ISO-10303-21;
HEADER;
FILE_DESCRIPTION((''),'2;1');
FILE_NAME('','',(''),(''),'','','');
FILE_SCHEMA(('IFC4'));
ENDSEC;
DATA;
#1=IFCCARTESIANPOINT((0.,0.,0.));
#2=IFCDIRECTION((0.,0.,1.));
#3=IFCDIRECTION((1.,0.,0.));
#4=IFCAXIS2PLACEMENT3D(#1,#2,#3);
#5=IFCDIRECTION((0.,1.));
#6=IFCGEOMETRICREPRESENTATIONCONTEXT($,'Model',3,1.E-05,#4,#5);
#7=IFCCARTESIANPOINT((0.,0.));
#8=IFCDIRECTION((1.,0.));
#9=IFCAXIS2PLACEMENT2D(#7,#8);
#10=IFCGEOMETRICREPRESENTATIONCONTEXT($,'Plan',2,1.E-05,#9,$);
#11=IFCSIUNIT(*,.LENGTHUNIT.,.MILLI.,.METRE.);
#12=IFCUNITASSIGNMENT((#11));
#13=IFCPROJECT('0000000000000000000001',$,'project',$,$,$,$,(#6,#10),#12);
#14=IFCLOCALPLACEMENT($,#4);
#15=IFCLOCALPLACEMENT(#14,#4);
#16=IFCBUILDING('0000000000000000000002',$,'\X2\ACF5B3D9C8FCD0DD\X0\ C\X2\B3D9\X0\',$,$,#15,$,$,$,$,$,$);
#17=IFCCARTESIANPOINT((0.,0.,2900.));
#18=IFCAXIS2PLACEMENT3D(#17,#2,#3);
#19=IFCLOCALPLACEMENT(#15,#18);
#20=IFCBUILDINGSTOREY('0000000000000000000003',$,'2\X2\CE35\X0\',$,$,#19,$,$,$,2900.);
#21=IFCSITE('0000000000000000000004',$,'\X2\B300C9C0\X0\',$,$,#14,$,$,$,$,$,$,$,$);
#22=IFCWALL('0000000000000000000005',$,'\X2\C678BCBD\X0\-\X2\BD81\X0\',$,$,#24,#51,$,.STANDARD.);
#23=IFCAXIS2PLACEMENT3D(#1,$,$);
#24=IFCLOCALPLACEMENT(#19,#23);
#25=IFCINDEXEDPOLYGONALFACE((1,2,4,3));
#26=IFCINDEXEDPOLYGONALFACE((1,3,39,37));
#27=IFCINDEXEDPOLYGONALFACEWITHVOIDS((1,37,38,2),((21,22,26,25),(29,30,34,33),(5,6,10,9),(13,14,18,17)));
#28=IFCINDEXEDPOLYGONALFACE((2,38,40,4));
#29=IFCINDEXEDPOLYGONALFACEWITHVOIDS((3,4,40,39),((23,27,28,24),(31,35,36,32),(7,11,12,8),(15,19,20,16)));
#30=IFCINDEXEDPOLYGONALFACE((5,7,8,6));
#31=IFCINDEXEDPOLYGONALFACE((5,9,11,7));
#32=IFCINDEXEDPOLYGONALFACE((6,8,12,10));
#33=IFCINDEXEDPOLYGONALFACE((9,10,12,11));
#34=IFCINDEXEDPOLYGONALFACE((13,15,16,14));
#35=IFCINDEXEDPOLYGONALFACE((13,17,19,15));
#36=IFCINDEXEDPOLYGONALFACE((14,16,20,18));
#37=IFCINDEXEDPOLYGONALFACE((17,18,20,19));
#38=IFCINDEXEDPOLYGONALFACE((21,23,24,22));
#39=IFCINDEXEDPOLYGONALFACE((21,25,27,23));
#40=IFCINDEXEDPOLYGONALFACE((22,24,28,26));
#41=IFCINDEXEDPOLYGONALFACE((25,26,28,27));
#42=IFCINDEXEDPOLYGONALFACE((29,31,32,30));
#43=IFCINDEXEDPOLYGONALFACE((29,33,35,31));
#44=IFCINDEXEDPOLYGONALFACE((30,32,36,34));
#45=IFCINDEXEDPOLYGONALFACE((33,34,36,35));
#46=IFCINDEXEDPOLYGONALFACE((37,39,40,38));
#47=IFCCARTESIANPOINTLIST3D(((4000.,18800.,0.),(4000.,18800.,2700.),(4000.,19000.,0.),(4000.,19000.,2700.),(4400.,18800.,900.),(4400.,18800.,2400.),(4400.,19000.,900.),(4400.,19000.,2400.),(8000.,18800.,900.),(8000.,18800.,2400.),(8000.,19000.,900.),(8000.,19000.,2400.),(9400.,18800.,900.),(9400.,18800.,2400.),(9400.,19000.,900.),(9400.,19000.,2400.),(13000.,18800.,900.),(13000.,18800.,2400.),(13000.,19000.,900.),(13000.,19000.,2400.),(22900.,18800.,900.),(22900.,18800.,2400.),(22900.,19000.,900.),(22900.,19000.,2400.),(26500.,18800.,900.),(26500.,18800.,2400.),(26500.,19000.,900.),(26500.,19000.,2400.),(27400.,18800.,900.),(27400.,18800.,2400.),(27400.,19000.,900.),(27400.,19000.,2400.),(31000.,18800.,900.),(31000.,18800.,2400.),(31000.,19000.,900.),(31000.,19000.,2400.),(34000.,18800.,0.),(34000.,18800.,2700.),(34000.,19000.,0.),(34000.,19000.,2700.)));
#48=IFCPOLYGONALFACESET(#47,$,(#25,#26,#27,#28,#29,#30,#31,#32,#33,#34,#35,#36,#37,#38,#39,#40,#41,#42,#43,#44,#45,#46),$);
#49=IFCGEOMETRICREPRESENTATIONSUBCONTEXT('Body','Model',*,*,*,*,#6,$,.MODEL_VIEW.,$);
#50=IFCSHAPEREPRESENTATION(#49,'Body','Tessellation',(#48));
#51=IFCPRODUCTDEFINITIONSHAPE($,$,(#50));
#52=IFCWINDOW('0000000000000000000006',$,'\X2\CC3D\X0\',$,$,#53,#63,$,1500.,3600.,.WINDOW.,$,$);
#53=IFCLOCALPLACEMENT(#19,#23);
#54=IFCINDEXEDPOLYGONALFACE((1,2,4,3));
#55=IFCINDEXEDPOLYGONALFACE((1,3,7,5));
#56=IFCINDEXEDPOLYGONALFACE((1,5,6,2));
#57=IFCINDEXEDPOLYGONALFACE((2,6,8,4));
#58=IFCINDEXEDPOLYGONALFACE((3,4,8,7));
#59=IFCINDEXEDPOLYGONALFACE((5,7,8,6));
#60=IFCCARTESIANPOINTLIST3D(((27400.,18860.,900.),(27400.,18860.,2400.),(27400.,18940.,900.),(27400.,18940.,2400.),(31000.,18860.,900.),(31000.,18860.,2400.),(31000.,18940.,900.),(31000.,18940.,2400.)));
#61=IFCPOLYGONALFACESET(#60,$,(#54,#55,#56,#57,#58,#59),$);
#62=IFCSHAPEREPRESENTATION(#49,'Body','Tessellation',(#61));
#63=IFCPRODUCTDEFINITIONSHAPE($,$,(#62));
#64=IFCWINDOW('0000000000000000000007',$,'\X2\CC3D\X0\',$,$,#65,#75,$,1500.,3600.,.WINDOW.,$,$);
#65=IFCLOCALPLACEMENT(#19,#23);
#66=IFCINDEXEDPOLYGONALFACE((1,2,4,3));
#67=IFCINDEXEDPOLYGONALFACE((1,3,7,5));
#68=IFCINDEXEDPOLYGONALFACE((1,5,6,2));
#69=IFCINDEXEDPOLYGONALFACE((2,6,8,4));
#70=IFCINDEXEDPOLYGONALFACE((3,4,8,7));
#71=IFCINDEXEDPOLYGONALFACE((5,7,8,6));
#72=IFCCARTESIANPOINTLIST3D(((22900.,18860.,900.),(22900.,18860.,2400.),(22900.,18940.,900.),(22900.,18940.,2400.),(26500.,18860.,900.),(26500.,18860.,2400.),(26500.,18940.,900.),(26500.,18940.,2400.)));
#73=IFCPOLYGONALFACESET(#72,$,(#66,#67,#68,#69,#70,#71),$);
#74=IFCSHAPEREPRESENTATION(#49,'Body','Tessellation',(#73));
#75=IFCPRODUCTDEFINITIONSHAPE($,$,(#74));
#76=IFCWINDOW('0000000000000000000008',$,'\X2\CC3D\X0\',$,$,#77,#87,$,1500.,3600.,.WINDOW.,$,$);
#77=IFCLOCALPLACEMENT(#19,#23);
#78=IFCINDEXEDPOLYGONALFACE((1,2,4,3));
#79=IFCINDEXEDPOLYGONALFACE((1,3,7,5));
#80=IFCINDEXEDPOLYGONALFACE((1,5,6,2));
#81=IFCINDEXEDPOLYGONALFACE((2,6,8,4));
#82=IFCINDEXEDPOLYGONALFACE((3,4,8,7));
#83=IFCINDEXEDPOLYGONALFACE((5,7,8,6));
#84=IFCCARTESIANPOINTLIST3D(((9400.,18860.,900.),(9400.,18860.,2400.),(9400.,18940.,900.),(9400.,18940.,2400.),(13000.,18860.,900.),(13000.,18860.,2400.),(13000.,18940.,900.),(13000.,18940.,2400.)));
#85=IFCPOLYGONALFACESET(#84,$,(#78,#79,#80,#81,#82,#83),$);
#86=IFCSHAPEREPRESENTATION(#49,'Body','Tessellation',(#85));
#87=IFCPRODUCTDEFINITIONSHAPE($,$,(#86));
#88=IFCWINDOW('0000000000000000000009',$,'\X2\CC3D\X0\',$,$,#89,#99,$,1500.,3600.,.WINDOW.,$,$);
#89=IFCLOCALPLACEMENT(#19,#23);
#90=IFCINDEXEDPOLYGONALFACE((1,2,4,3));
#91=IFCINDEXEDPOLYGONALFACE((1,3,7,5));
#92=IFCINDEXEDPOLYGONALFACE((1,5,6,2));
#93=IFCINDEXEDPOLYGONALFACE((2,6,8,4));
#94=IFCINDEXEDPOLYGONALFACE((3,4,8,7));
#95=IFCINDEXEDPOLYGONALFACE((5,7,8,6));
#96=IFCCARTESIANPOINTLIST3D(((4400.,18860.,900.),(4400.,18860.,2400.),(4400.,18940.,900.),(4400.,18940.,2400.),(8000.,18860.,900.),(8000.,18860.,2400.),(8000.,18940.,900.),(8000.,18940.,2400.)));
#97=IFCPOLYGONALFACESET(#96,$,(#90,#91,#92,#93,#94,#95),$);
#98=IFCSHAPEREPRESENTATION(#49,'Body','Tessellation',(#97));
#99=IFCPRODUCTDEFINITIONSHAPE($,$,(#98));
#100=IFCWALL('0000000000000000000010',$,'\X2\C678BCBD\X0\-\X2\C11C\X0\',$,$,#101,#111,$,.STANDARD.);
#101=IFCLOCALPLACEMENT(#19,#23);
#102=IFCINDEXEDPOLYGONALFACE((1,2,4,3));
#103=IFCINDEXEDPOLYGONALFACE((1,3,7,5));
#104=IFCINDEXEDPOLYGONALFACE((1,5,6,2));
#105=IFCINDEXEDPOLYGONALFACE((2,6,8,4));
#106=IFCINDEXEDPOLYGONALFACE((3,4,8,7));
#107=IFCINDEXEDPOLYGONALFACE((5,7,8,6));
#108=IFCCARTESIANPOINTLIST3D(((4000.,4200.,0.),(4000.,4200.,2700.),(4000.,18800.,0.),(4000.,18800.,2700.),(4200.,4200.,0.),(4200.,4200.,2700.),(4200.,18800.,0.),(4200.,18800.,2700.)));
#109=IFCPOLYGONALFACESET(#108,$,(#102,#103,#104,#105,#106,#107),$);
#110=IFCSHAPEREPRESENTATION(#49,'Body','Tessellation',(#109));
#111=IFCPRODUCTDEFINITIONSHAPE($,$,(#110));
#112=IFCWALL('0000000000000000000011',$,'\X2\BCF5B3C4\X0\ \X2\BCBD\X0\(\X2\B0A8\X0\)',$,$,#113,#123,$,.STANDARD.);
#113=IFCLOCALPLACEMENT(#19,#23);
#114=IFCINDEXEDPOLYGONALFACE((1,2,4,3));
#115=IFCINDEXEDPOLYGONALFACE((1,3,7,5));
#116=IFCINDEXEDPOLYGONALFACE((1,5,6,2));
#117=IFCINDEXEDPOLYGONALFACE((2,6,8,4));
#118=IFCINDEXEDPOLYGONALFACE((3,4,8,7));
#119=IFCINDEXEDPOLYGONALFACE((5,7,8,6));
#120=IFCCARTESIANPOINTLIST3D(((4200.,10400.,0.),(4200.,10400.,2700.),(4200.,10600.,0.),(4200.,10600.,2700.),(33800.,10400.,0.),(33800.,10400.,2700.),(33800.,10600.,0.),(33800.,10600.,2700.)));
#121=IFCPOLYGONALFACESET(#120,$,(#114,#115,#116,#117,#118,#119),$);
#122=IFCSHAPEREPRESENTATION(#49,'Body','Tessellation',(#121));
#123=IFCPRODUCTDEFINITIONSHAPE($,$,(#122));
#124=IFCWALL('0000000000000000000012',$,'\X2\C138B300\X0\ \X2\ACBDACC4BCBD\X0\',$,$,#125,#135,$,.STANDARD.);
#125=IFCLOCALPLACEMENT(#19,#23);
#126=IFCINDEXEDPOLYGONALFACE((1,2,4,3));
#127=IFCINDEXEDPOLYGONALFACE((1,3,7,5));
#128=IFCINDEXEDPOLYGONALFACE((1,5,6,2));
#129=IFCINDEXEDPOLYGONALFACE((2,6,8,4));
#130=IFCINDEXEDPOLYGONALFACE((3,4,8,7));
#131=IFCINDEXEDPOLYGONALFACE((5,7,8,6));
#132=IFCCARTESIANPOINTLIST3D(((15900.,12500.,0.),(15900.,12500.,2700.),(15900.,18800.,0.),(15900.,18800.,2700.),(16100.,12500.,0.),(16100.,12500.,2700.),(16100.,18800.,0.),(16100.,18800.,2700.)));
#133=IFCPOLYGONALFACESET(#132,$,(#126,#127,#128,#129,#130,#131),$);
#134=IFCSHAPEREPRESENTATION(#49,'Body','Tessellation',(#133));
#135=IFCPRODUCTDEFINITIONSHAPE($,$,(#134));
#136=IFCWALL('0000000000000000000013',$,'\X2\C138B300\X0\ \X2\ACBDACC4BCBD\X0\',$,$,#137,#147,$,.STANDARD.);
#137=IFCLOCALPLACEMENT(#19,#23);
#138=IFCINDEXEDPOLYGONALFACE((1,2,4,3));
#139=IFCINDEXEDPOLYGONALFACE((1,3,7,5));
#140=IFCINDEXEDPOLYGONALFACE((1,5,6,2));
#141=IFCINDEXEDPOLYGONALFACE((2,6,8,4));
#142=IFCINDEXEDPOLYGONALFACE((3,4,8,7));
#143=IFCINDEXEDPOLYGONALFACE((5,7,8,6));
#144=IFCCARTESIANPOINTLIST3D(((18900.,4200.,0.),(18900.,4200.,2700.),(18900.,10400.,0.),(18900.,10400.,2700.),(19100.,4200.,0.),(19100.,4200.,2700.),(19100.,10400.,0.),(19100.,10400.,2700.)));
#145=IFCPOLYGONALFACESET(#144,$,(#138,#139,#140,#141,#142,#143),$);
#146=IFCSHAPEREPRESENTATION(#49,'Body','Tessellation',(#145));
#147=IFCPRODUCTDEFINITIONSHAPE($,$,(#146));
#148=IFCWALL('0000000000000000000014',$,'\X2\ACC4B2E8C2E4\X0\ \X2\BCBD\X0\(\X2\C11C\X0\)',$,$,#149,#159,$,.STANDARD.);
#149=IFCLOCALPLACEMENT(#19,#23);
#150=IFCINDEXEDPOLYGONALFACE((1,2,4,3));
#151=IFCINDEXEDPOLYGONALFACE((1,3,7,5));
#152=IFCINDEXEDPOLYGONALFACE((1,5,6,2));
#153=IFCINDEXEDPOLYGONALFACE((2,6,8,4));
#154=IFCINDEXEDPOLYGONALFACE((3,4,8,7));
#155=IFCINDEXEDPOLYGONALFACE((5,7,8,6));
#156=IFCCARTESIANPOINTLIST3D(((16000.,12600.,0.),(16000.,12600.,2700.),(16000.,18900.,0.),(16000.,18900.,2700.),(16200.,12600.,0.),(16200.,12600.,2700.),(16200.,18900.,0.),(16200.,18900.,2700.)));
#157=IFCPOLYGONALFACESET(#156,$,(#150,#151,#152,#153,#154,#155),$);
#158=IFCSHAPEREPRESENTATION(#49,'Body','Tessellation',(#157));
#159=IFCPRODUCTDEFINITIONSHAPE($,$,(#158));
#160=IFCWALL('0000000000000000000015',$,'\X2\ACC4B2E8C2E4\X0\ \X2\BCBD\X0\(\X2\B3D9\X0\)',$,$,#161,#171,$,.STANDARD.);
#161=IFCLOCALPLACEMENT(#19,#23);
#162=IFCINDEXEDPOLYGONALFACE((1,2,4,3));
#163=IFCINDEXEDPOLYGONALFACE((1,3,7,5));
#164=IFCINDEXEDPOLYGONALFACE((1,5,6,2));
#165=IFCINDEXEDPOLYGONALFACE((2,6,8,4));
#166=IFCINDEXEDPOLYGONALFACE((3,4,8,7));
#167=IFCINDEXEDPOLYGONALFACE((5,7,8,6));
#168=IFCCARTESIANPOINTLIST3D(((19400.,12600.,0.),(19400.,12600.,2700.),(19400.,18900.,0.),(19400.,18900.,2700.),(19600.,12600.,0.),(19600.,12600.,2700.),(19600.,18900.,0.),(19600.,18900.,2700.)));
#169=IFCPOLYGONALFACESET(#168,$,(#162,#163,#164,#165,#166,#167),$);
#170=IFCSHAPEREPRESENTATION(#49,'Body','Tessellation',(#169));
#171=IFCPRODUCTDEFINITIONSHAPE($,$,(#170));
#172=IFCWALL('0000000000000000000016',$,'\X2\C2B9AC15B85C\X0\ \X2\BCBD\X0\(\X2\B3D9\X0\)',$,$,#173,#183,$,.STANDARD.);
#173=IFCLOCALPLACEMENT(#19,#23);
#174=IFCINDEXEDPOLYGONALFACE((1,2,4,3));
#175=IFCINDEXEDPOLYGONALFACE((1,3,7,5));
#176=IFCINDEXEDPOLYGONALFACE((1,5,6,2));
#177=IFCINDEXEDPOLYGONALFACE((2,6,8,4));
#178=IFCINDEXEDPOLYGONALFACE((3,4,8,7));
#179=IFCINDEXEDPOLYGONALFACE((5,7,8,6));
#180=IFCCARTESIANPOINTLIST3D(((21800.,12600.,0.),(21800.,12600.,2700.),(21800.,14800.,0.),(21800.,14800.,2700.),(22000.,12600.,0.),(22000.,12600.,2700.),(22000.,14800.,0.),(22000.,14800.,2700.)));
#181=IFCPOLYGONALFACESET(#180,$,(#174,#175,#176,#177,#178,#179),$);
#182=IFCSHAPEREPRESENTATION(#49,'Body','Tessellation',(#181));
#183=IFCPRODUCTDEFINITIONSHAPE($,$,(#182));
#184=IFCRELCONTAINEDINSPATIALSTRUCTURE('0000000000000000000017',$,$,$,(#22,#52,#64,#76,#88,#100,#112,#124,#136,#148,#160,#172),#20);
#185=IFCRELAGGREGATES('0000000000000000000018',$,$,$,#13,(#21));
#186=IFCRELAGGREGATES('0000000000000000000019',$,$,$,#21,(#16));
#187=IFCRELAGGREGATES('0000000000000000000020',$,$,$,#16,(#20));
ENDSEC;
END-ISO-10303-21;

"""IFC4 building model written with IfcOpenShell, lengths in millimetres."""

from ifc_helpers import new_model, si_unit, direction, frame, origin_with_axes, origin_2d_with_axis, place, context, subcontext, project, spatial, polyline, outline, extrude, element, fill, save


model = new_model("IFC4")

# Units and contexts
model_context = context("Model", 3, precision=1e-05, world=origin_with_axes(), true_north=direction((0.0, 1.0)))
plan_context = context("Plan", 2, precision=1e-05, world=origin_2d_with_axis())
body_context = subcontext(model_context, "Body", "Model", "MODEL_VIEW")
ifc_project = project(units=[si_unit("LENGTHUNIT", "METRE", prefix="MILLI")], contexts=[model_context, plan_context])

# Site, building, storey
site_placement = place(None, origin_with_axes())
site = spatial("IfcSite", under=ifc_project, at=site_placement, Name="대지")
building_placement = place(site_placement, origin_with_axes())
building = spatial("IfcBuilding", under=site, at=building_placement, Name="공동주택 C동")
storey_placement = place(building_placement, frame((0.0, 0.0, 2900.0), z_axis=(0.0, 0.0, 1.0), x_axis=(1.0, 0.0, 0.0)))
storey = spatial("IfcBuildingStorey", under=building, at=storey_placement, Name="2층", Elevation=2900.0)

# Wall, openings, windows
wall_1_placement = place(storey_placement, origin_with_axes())
wall_1 = element("IfcWall", 1, at=wall_1_placement, inside=storey, Name="외벽-북", PredefinedType="STANDARD", context=body_context, shape_type="SweptSolid", body=[
    extrude(outline(polyline([(34000.0, 18800.0), (4000.0, 18800.0), (4000.0, 19000.0), (34000.0, 19000.0), (34000.0, 18800.0)])), origin_with_axes(), (0.0, 0.0, 1.0), 2700.0),
])
opening_1_placement = place(storey_placement, origin_with_axes())
opening_1 = element("IfcOpeningElement", 2, at=opening_1_placement, cuts=wall_1, PredefinedType="OPENING", context=body_context, shape_type="SweptSolid", body=[
    extrude(outline(polyline([(31000.0, 19050.0), (27400.0, 19050.0), (27400.0, 18750.0), (31000.0, 18750.0), (31000.0, 19050.0)])), frame((0.0, 0.0, 900.0), z_axis=(0.0, 0.0, 1.0), x_axis=(1.0, 0.0, 0.0)), (0.0, 0.0, 1.0), 1500.0),
])
opening_2_placement = place(storey_placement, origin_with_axes())
opening_2 = element("IfcOpeningElement", 3, at=opening_2_placement, cuts=wall_1, PredefinedType="OPENING", context=body_context, shape_type="SweptSolid", body=[
    extrude(outline(polyline([(26500.0, 19050.0), (22900.0, 19050.0), (22900.0, 18750.0), (26500.0, 18750.0), (26500.0, 19050.0)])), frame((0.0, 0.0, 900.0), z_axis=(0.0, 0.0, 1.0), x_axis=(1.0, 0.0, 0.0)), (0.0, 0.0, 1.0), 1500.0),
])
opening_3_placement = place(storey_placement, origin_with_axes())
opening_3 = element("IfcOpeningElement", 4, at=opening_3_placement, cuts=wall_1, PredefinedType="OPENING", context=body_context, shape_type="SweptSolid", body=[
    extrude(outline(polyline([(13000.0, 19050.0), (9400.0, 19050.0), (9400.0, 18750.0), (13000.0, 18750.0), (13000.0, 19050.0)])), frame((0.0, 0.0, 900.0), z_axis=(0.0, 0.0, 1.0), x_axis=(1.0, 0.0, 0.0)), (0.0, 0.0, 1.0), 1500.0),
])
opening_4_placement = place(storey_placement, origin_with_axes())
opening_4 = element("IfcOpeningElement", 5, at=opening_4_placement, cuts=wall_1, PredefinedType="OPENING", context=body_context, shape_type="SweptSolid", body=[
    extrude(outline(polyline([(8000.0, 19050.0), (4400.0, 19050.0), (4400.0, 18750.0), (8000.0, 18750.0), (8000.0, 19050.0)])), frame((0.0, 0.0, 900.0), z_axis=(0.0, 0.0, 1.0), x_axis=(1.0, 0.0, 0.0)), (0.0, 0.0, 1.0), 1500.0),
])
window_1_placement = place(storey_placement, origin_with_axes())
window_1 = element("IfcWindow", 6, at=window_1_placement, inside=storey, Name="창", OverallHeight=1500.0, OverallWidth=3600.0, PredefinedType="WINDOW", context=body_context, shape_type="SweptSolid", body=[
    extrude(outline(polyline([(31000.0, 18940.0), (27400.0, 18940.0), (27400.0, 18860.0), (31000.0, 18860.0), (31000.0, 18940.0)])), frame((0.0, 0.0, 900.0), z_axis=(0.0, 0.0, 1.0), x_axis=(1.0, 0.0, 0.0)), (0.0, 0.0, 1.0), 1500.0),
])
fill(opening_1, window_1)
window_2_placement = place(storey_placement, origin_with_axes())
window_2 = element("IfcWindow", 7, at=window_2_placement, inside=storey, Name="창", OverallHeight=1500.0, OverallWidth=3600.0, PredefinedType="WINDOW", context=body_context, shape_type="SweptSolid", body=[
    extrude(outline(polyline([(26500.0, 18940.0), (22900.0, 18940.0), (22900.0, 18860.0), (26500.0, 18860.0), (26500.0, 18940.0)])), frame((0.0, 0.0, 900.0), z_axis=(0.0, 0.0, 1.0), x_axis=(1.0, 0.0, 0.0)), (0.0, 0.0, 1.0), 1500.0),
])
fill(opening_2, window_2)
window_3_placement = place(storey_placement, origin_with_axes())
window_3 = element("IfcWindow", 8, at=window_3_placement, inside=storey, Name="창", OverallHeight=1500.0, OverallWidth=3600.0, PredefinedType="WINDOW", context=body_context, shape_type="SweptSolid", body=[
    extrude(outline(polyline([(13000.0, 18940.0), (9400.0, 18940.0), (9400.0, 18860.0), (13000.0, 18860.0), (13000.0, 18940.0)])), frame((0.0, 0.0, 900.0), z_axis=(0.0, 0.0, 1.0), x_axis=(1.0, 0.0, 0.0)), (0.0, 0.0, 1.0), 1500.0),
])
fill(opening_3, window_3)
window_4_placement = place(storey_placement, origin_with_axes())
window_4 = element("IfcWindow", 9, at=window_4_placement, inside=storey, Name="창", OverallHeight=1500.0, OverallWidth=3600.0, PredefinedType="WINDOW", context=body_context, shape_type="SweptSolid", body=[
    extrude(outline(polyline([(8000.0, 18940.0), (4400.0, 18940.0), (4400.0, 18860.0), (8000.0, 18860.0), (8000.0, 18940.0)])), frame((0.0, 0.0, 900.0), z_axis=(0.0, 0.0, 1.0), x_axis=(1.0, 0.0, 0.0)), (0.0, 0.0, 1.0), 1500.0),
])
fill(opening_4, window_4)

# Walls
wall_2_placement = place(storey_placement, origin_with_axes())
element("IfcWall", 10, at=wall_2_placement, inside=storey, Name="외벽-서", PredefinedType="STANDARD", context=body_context, shape_type="SweptSolid", body=[
    extrude(outline(polyline([(4200.0, 18800.0), (4200.0, 4200.0), (4000.0, 4200.0), (4000.0, 18800.0), (4200.0, 18800.0)])), origin_with_axes(), (0.0, 0.0, 1.0), 2700.0),
])
wall_3_placement = place(storey_placement, origin_with_axes())
element("IfcWall", 11, at=wall_3_placement, inside=storey, Name="복도 벽(남)", PredefinedType="STANDARD", context=body_context, shape_type="SweptSolid", body=[
    extrude(outline(polyline([(4200.0, 10600.0), (33800.0, 10600.0), (33800.0, 10400.0), (4200.0, 10400.0), (4200.0, 10600.0)])), origin_with_axes(), (0.0, 0.0, 1.0), 2700.0),
])
wall_4_placement = place(storey_placement, origin_with_axes())
element("IfcWall", 12, at=wall_4_placement, inside=storey, Name="세대 경계벽", PredefinedType="STANDARD", context=body_context, shape_type="SweptSolid", body=[
    extrude(outline(polyline([(15900.0, 12500.0), (15900.0, 18800.0), (16100.0, 18800.0), (16100.0, 12500.0), (15900.0, 12500.0)])), origin_with_axes(), (0.0, 0.0, 1.0), 2700.0),
])
wall_5_placement = place(storey_placement, origin_with_axes())
element("IfcWall", 13, at=wall_5_placement, inside=storey, Name="세대 경계벽", PredefinedType="STANDARD", context=body_context, shape_type="SweptSolid", body=[
    extrude(outline(polyline([(18900.0, 4200.0), (18900.0, 10400.0), (19100.0, 10400.0), (19100.0, 4200.0), (18900.0, 4200.0)])), origin_with_axes(), (0.0, 0.0, 1.0), 2700.0),
])
wall_6_placement = place(storey_placement, origin_with_axes())
element("IfcWall", 14, at=wall_6_placement, inside=storey, Name="계단실 벽(서)", PredefinedType="STANDARD", context=body_context, shape_type="SweptSolid", body=[
    extrude(outline(polyline([(16000.0, 12600.0), (16000.0, 18900.0), (16200.0, 18900.0), (16200.0, 12600.0), (16000.0, 12600.0)])), origin_with_axes(), (0.0, 0.0, 1.0), 2700.0),
])
wall_7_placement = place(storey_placement, origin_with_axes())
element("IfcWall", 15, at=wall_7_placement, inside=storey, Name="계단실 벽(동)", PredefinedType="STANDARD", context=body_context, shape_type="SweptSolid", body=[
    extrude(outline(polyline([(19400.0, 12600.0), (19400.0, 18900.0), (19600.0, 18900.0), (19600.0, 12600.0), (19400.0, 12600.0)])), origin_with_axes(), (0.0, 0.0, 1.0), 2700.0),
])
wall_8_placement = place(storey_placement, origin_with_axes())
element("IfcWall", 16, at=wall_8_placement, inside=storey, Name="승강로 벽(동)", PredefinedType="STANDARD", context=body_context, shape_type="SweptSolid", body=[
    extrude(outline(polyline([(21800.0, 12600.0), (21800.0, 14800.0), (22000.0, 14800.0), (22000.0, 12600.0), (21800.0, 12600.0)])), origin_with_axes(), (0.0, 0.0, 1.0), 2700.0),
])

save(model, "model.ifc")
